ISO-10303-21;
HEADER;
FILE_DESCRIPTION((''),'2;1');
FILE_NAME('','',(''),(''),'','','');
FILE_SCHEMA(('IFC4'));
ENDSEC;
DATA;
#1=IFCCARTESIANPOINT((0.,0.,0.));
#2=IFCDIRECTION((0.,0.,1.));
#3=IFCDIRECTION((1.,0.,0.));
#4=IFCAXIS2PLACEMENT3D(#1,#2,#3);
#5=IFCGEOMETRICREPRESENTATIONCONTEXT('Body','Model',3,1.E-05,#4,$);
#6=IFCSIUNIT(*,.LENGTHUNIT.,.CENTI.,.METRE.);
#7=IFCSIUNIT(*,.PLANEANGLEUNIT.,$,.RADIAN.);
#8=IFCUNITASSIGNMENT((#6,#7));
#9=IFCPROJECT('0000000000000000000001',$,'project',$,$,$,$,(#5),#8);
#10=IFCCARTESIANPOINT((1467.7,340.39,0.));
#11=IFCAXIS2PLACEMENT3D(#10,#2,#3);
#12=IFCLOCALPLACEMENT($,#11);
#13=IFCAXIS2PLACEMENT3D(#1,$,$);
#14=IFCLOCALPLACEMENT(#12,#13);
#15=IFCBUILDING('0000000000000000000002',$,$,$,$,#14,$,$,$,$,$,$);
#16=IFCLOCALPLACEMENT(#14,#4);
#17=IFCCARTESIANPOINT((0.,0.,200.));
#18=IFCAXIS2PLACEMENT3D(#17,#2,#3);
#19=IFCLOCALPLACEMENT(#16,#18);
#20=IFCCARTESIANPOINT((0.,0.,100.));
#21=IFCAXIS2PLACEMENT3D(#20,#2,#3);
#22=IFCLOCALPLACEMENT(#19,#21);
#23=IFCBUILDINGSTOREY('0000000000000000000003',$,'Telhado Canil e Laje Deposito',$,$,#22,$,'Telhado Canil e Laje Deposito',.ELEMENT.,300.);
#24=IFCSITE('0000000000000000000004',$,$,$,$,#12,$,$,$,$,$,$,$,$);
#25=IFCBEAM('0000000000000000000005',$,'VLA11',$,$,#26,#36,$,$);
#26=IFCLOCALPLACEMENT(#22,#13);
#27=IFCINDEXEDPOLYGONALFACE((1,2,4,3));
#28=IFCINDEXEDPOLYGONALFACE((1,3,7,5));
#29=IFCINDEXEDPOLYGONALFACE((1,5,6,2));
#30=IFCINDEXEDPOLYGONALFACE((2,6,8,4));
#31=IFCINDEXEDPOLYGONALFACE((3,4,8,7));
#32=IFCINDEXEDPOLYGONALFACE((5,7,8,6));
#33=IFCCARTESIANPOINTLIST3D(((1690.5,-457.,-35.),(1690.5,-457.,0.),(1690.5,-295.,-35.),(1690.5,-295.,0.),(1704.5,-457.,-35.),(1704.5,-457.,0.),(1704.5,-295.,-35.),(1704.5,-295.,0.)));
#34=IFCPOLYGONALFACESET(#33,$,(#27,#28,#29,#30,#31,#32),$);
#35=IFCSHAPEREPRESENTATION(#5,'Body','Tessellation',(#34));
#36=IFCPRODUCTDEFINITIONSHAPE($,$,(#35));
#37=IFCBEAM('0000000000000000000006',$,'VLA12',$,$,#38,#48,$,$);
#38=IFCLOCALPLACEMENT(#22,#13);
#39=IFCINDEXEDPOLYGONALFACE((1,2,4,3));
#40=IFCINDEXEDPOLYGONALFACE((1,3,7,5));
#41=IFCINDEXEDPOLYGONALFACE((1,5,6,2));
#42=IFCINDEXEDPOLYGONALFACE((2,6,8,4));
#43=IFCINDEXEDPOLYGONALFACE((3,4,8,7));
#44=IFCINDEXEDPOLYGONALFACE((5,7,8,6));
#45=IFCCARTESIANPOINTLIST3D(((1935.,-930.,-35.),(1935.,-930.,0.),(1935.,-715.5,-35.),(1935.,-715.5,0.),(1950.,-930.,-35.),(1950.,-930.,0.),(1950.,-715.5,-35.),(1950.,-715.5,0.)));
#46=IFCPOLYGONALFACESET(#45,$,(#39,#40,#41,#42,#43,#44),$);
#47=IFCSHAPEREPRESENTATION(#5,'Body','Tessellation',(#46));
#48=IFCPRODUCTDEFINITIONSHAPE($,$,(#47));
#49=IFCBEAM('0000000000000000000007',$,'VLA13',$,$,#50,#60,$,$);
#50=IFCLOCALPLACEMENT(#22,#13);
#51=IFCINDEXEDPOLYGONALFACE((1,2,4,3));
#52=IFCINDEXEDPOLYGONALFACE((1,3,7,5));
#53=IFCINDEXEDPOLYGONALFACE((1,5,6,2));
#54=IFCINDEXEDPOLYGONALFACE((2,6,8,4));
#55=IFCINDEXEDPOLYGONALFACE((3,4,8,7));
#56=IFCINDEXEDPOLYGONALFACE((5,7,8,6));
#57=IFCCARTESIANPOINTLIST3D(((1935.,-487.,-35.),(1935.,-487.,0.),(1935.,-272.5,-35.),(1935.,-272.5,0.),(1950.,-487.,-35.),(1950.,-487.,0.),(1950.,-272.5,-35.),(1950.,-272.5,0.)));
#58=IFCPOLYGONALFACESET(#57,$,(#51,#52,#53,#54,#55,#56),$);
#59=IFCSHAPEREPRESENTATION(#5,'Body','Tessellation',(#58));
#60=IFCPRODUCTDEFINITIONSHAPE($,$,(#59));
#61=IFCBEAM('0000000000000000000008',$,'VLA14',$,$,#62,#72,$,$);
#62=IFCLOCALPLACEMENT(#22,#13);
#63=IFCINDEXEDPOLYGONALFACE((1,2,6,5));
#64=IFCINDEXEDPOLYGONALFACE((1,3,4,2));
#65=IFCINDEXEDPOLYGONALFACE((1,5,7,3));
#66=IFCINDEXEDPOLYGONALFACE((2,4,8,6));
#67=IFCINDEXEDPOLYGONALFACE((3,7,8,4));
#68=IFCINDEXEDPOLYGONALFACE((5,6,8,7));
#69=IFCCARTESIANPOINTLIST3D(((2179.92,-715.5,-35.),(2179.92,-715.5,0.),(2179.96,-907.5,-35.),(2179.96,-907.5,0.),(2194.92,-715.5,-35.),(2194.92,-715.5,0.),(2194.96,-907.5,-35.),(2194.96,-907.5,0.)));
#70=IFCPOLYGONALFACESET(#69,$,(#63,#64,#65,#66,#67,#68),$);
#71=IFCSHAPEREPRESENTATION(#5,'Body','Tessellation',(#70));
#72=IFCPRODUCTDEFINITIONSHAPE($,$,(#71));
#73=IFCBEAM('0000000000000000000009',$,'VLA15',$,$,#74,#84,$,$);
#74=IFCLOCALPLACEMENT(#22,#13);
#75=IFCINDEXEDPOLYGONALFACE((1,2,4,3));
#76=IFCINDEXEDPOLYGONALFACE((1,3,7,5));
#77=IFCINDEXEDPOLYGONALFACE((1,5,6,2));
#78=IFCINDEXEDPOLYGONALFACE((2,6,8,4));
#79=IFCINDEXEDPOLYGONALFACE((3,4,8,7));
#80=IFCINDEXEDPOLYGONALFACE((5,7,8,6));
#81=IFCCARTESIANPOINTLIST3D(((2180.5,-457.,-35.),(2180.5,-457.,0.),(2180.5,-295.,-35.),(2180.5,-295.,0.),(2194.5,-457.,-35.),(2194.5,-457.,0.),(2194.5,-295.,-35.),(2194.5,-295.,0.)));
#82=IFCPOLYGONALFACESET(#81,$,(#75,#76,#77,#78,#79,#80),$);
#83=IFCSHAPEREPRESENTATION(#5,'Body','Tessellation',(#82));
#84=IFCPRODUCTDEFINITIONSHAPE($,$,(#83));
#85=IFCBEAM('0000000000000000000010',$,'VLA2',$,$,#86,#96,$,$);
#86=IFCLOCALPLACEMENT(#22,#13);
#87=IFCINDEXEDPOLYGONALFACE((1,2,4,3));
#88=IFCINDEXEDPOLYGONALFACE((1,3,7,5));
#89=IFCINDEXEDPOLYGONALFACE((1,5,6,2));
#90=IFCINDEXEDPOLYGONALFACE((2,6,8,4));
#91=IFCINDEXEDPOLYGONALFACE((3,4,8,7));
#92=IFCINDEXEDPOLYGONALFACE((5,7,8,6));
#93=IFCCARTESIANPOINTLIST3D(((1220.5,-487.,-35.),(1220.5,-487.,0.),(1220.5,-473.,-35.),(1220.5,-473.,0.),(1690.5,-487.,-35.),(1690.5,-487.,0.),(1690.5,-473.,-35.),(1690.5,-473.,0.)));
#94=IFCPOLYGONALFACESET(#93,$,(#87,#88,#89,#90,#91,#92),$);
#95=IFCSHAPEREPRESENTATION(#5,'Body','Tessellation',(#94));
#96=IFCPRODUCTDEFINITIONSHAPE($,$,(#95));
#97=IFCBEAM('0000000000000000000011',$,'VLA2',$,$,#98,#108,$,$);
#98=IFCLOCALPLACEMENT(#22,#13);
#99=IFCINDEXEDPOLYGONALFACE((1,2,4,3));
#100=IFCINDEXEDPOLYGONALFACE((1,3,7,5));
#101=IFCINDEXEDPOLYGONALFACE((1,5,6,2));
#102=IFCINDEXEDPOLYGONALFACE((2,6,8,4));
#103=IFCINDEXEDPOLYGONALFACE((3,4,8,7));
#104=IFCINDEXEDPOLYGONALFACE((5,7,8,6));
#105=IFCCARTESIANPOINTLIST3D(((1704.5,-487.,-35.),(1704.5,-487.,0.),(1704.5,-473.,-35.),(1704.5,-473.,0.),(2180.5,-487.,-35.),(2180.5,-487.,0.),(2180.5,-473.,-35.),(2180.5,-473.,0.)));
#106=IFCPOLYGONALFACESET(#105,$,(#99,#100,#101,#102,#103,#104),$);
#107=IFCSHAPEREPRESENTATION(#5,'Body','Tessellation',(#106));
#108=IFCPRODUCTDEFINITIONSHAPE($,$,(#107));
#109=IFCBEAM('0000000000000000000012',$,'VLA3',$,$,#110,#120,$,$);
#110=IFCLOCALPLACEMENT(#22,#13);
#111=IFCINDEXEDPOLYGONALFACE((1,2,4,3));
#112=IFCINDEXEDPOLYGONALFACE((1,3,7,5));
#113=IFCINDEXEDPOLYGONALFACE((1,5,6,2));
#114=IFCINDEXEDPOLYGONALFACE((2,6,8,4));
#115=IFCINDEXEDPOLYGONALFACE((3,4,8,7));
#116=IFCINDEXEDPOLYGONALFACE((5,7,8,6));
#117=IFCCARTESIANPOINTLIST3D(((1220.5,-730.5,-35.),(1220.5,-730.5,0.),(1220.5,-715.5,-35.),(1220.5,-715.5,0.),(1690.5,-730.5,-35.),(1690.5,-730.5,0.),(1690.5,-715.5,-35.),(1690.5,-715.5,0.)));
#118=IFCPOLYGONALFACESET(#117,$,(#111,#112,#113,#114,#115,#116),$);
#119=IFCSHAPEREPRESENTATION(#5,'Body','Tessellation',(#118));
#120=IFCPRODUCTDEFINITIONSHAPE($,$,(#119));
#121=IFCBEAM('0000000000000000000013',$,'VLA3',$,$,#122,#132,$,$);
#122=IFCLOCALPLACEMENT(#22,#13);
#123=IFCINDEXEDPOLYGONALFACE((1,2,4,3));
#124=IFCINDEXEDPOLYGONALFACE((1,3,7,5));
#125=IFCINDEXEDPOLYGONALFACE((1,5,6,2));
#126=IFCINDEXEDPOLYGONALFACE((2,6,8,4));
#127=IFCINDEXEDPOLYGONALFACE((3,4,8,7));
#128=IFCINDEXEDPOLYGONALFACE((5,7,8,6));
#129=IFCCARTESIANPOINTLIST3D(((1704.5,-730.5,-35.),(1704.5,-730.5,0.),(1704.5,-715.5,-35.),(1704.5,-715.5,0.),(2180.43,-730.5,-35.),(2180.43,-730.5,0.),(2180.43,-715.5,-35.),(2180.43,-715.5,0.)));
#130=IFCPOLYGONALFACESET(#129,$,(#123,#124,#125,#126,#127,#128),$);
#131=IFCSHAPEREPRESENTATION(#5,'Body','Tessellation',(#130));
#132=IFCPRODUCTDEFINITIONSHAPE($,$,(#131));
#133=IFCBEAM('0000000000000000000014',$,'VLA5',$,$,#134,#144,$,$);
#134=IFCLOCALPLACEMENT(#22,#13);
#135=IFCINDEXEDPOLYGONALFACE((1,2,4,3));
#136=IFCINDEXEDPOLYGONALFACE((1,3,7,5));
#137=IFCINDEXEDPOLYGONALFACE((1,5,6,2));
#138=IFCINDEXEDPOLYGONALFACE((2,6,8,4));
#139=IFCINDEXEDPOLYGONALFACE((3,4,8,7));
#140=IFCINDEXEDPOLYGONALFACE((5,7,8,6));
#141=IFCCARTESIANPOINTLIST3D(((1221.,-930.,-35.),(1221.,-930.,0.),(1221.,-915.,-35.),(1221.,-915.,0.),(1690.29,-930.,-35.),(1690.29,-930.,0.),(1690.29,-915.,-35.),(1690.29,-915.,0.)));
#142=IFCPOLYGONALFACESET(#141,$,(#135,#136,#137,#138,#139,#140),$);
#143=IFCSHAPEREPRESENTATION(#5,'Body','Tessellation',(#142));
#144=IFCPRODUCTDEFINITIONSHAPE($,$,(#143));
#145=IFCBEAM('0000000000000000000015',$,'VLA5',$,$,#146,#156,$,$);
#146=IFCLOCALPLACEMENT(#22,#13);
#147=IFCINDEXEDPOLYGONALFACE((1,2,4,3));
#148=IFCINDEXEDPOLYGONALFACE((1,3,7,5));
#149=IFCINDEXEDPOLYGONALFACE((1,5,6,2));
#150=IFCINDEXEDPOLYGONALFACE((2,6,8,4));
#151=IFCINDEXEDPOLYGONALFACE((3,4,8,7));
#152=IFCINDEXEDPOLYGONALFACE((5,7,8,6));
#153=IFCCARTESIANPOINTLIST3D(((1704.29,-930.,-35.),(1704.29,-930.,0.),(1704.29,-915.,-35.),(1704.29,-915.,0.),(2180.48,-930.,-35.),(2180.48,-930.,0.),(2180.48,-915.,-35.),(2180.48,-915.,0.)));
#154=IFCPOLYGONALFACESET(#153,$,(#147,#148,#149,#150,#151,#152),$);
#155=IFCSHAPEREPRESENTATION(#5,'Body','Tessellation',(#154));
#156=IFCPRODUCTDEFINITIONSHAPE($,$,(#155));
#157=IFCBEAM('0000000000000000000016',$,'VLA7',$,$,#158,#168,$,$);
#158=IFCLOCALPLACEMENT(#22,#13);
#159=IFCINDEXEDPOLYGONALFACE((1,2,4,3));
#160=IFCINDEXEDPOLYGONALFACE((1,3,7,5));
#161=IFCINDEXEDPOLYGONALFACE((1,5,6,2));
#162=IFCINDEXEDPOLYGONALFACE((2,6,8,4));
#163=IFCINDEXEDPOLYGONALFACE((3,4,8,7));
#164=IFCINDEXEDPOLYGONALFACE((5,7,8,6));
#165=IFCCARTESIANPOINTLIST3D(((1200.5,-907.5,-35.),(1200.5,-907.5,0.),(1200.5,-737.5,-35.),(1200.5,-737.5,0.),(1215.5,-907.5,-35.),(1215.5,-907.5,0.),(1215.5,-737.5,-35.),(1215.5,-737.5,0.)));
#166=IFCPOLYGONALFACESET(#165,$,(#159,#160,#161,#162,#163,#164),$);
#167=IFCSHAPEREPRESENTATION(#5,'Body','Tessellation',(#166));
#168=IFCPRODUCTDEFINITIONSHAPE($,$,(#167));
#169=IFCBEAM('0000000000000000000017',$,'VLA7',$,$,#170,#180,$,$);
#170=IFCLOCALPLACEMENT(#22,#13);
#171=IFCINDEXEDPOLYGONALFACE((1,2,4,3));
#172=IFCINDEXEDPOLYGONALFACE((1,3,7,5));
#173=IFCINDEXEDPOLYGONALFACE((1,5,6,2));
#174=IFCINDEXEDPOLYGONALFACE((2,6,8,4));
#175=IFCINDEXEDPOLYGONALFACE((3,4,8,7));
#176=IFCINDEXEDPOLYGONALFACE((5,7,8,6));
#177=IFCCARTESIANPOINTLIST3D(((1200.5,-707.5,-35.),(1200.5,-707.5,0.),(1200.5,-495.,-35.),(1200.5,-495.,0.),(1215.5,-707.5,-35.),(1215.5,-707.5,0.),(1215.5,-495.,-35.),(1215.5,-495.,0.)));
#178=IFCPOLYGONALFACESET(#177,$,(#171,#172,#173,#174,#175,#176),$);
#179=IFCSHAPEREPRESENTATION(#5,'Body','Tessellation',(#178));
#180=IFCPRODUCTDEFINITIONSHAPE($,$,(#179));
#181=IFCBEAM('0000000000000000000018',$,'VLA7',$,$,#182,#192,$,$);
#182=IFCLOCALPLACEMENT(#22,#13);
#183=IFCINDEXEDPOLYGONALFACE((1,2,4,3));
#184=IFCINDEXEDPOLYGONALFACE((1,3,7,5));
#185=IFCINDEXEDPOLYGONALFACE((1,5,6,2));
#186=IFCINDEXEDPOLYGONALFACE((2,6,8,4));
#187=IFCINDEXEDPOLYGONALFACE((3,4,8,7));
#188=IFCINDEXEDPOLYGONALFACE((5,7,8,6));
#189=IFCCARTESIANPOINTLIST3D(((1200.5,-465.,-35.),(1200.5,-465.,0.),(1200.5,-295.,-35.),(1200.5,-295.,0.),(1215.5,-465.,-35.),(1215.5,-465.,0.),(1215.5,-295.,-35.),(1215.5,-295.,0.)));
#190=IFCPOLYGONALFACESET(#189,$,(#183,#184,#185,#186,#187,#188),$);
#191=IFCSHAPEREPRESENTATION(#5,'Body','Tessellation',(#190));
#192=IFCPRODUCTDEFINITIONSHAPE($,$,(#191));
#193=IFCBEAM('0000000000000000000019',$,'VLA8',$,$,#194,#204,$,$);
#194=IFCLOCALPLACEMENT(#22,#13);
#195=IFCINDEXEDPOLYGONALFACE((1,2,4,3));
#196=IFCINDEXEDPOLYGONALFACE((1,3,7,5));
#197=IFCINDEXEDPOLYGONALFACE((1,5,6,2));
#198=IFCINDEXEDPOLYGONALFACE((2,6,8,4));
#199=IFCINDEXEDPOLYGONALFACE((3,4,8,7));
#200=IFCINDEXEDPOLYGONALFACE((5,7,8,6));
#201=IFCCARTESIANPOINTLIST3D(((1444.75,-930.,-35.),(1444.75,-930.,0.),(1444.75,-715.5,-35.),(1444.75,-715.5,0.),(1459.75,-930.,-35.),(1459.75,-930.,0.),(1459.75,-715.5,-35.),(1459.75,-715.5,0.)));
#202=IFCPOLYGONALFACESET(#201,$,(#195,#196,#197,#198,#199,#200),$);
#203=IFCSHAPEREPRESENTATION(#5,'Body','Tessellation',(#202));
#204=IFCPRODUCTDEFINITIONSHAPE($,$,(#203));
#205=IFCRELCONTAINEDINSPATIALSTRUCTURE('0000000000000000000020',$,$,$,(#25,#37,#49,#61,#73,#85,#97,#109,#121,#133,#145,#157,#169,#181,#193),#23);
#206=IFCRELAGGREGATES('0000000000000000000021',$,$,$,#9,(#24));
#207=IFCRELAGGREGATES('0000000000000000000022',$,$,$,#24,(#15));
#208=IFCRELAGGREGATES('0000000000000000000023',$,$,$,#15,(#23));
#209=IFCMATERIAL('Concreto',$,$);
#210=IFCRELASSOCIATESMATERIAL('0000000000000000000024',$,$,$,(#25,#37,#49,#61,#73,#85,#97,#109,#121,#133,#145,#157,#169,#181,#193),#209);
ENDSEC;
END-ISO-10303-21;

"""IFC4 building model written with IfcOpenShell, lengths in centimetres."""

from ifc_helpers import new_model, si_unit, frame, origin, origin_with_axes, origin_2d_with_axis, place, context, project, spatial, rectangle, extrude, material, element, save


model = new_model("IFC4")

# Units and contexts
model_context = context("Model", 3, precision=1e-05, world=origin_with_axes(), identifier="Body")
ifc_project = project(units=[si_unit("LENGTHUNIT", "METRE", prefix="CENTI"), si_unit("PLANEANGLEUNIT", "RADIAN")], contexts=[model_context])

# Site, building, storey
site_placement = place(None, frame((1467.7, 340.39, 0.0), z_axis=(0.0, 0.0, 1.0), x_axis=(1.0, 0.0, 0.0)))
site = spatial("IfcSite", under=ifc_project, at=site_placement)
building_placement = place(site_placement, origin())
building = spatial("IfcBuilding", under=site, at=building_placement)
placement_1 = place(building_placement, origin_with_axes())
placement_2 = place(placement_1, frame((0.0, 0.0, 200.0), z_axis=(0.0, 0.0, 1.0), x_axis=(1.0, 0.0, 0.0)))
storey_placement = place(placement_2, frame((0.0, 0.0, 100.0), z_axis=(0.0, 0.0, 1.0), x_axis=(1.0, 0.0, 0.0)))
storey = spatial("IfcBuildingStorey", under=building, at=storey_placement, Name="Telhado Canil e Laje Deposito", LongName="Telhado Canil e Laje Deposito", CompositionType="ELEMENT", Elevation=300.0)

# Shared definitions
ifc_material = material(Name="Concreto")

# Beams
beam_1_placement = place(storey_placement, frame((1697.5, -376.0, 0.0), z_axis=(0.0, 0.0, 1.0), x_axis=(1.0, 0.0, 0.0)))
element("IfcBeam", 1, at=beam_1_placement, inside=storey, material=ifc_material, Name="VLA11", context=model_context, shape_type="SolidModel", body=[
    extrude(rectangle(XDim=14.0, YDim=35.0, at=origin_2d_with_axis()), frame((0.0, -81.0, -17.5), z_axis=(0.0, 1.0, 0.0), x_axis=(1.0, 0.0, 0.0)), (0.0, 0.0, 1.0), 162.0),
])
for number, where, z_axis, x_axis, name in (
    (2, (1942.5, -822.75, 0.0), (0.0, 0.0, 1.0), (1.0, 0.0, 0.0), "VLA12"),
    (3, (1942.5, -379.75, 0.0), (0.0, 0.0, 1.0), (1.0, 0.0, 0.0), "VLA13"),
):
    element("IfcBeam", number, at=place(storey_placement, frame(where, z_axis=z_axis, x_axis=x_axis)), inside=storey, material=ifc_material, Name=name, context=model_context, shape_type="SolidModel", body=[
        extrude(rectangle(XDim=15.0, YDim=35.0, at=origin_2d_with_axis()), frame((0.0, -107.25, -17.5), z_axis=(0.0, 1.0, 0.0), x_axis=(1.0, 0.0, 0.0)), (0.0, 0.0, 1.0), 214.5),
    ])
beam_2_placement = place(storey_placement, frame((2187.44, -811.5, 0.0), z_axis=(0.0, 0.0, 1.0), x_axis=(1.0, 0.0, 0.0)))
element("IfcBeam", 4, at=beam_2_placement, inside=storey, material=ifc_material, Name="VLA14", context=model_context, shape_type="SolidModel", body=[
    extrude(rectangle(XDim=15.0, YDim=35.0, at=origin_2d_with_axis()), frame((0.02, -96.0, -17.5), z_axis=(-0.000185, 1.0, 0.0), x_axis=(1.0, 0.000185, 0.0)), (0.0, 0.0, 1.0), 192.0),
])
beam_3_placement = place(storey_placement, frame((2187.5, -376.0, 0.0), z_axis=(0.0, 0.0, 1.0), x_axis=(1.0, 0.0, 0.0)))
element("IfcBeam", 5, at=beam_3_placement, inside=storey, material=ifc_material, Name="VLA15", context=model_context, shape_type="SolidModel", body=[
    extrude(rectangle(XDim=14.0, YDim=35.0, at=origin_2d_with_axis()), frame((0.0, -81.0, -17.5), z_axis=(0.0, 1.0, 0.0), x_axis=(1.0, 0.0, 0.0)), (0.0, 0.0, 1.0), 162.0),
])
beam_4_placement = place(storey_placement, frame((1455.5, -480.0, 0.0), z_axis=(0.0, 0.0, 1.0), x_axis=(1.0, 0.0, 0.0)))
element("IfcBeam", 6, at=beam_4_placement, inside=storey, material=ifc_material, Name="VLA2", context=model_context, shape_type="SolidModel", body=[
    extrude(rectangle(XDim=14.0, YDim=35.0, at=origin_2d_with_axis()), frame((-235.0, 0.0, -17.5), z_axis=(1.0, 0.0, 0.0), x_axis=(0.0, 1.0, 0.0)), (0.0, 0.0, 1.0), 470.0),
])
beam_5_placement = place(storey_placement, frame((1942.5, -480.0, 0.0), z_axis=(0.0, 0.0, 1.0), x_axis=(1.0, 0.0, 0.0)))
element("IfcBeam", 7, at=beam_5_placement, inside=storey, material=ifc_material, Name="VLA2", context=model_context, shape_type="SolidModel", body=[
    extrude(rectangle(XDim=14.0, YDim=35.0, at=origin_2d_with_axis()), frame((-238.0, 0.0, -17.5), z_axis=(1.0, 0.0, 0.0), x_axis=(0.0, 1.0, 0.0)), (0.0, 0.0, 1.0), 476.0),
])
beam_6_placement = place(storey_placement, frame((1455.5, -723.0, 0.0), z_axis=(0.0, 0.0, 1.0), x_axis=(1.0, 0.0, 0.0)))
element("IfcBeam", 8, at=beam_6_placement, inside=storey, material=ifc_material, Name="VLA3", context=model_context, shape_type="SolidModel", body=[
    extrude(rectangle(XDim=15.0, YDim=35.0, at=origin_2d_with_axis()), frame((-235.0, 0.0, -17.5), z_axis=(1.0, 0.0, 0.0), x_axis=(0.0, 1.0, 0.0)), (0.0, 0.0, 1.0), 470.0),
])
beam_7_placement = place(storey_placement, frame((1942.46, -723.0, 0.0), z_axis=(0.0, 0.0, 1.0), x_axis=(1.0, 0.0, 0.0)))
element("IfcBeam", 9, at=beam_7_placement, inside=storey, material=ifc_material, Name="VLA3", context=model_context, shape_type="SolidModel", body=[
    extrude(rectangle(XDim=15.0, YDim=35.0, at=origin_2d_with_axis()), frame((-237.97, 0.0, -17.5), z_axis=(1.0, 0.0, 0.0), x_axis=(0.0, 1.0, 0.0)), (0.0, 0.0, 1.0), 475.93),
])
beam_8_placement = place(storey_placement, frame((1455.64, -922.5, 0.0), z_axis=(0.0, 0.0, 1.0), x_axis=(1.0, 0.0, 0.0)))
element("IfcBeam", 10, at=beam_8_placement, inside=storey, material=ifc_material, Name="VLA5", context=model_context, shape_type="SolidModel", body=[
    extrude(rectangle(XDim=15.0, YDim=35.0, at=origin_2d_with_axis()), frame((-234.65, 0.0, -17.5), z_axis=(1.0, 0.0, 0.0), x_axis=(0.0, -1.0, 0.0)), (0.0, 0.0, 1.0), 469.29),
])
beam_9_placement = place(storey_placement, frame((1942.38, -922.5, 0.0), z_axis=(0.0, 0.0, 1.0), x_axis=(1.0, 0.0, 0.0)))
element("IfcBeam", 11, at=beam_9_placement, inside=storey, material=ifc_material, Name="VLA5", context=model_context, shape_type="SolidModel", body=[
    extrude(rectangle(XDim=15.0, YDim=35.0, at=origin_2d_with_axis()), frame((-238.09, 0.0, -17.5), z_axis=(1.0, 0.0, 0.0), x_axis=(0.0, 1.0, 0.0)), (0.0, 0.0, 1.0), 476.19),
])
beam_10_placement = place(storey_placement, frame((1208.0, -822.5, 0.0), z_axis=(0.0, 0.0, 1.0), x_axis=(1.0, 0.0, 0.0)))
element("IfcBeam", 12, at=beam_10_placement, inside=storey, material=ifc_material, Name="VLA7", context=model_context, shape_type="SolidModel", body=[
    extrude(rectangle(XDim=15.0, YDim=35.0, at=origin_2d_with_axis()), frame((0.0, -85.0, -17.5), z_axis=(0.0, 1.0, 0.0), x_axis=(1.0, 0.0, 0.0)), (0.0, 0.0, 1.0), 170.0),
])
beam_11_placement = place(storey_placement, frame((1208.0, -601.25, 0.0), z_axis=(0.0, 0.0, 1.0), x_axis=(1.0, 0.0, 0.0)))
element("IfcBeam", 13, at=beam_11_placement, inside=storey, material=ifc_material, Name="VLA7", context=model_context, shape_type="SolidModel", body=[
    extrude(rectangle(XDim=15.0, YDim=35.0, at=origin_2d_with_axis()), frame((0.0, -106.25, -17.5), z_axis=(0.0, 1.0, 0.0), x_axis=(1.0, 0.0, 0.0)), (0.0, 0.0, 1.0), 212.5),
])
beam_12_placement = place(storey_placement, frame((1208.0, -380.0, 0.0), z_axis=(0.0, 0.0, 1.0), x_axis=(1.0, 0.0, 0.0)))
element("IfcBeam", 14, at=beam_12_placement, inside=storey, material=ifc_material, Name="VLA7", context=model_context, shape_type="SolidModel", body=[
    extrude(rectangle(XDim=15.0, YDim=35.0, at=origin_2d_with_axis()), frame((0.0, -85.0, -17.5), z_axis=(0.0, 1.0, 0.0), x_axis=(1.0, 0.0, 0.0)), (0.0, 0.0, 1.0), 170.0),
])
for number, where, z_axis, x_axis, name in (
    (15, (1452.25, -822.75, 0.0), (0.0, 0.0, 1.0), (1.0, 0.0, 0.0), "VLA8"),
):
    element("IfcBeam", number, at=place(storey_placement, frame(where, z_axis=z_axis, x_axis=x_axis)), inside=storey, material=ifc_material, Name=name, context=model_context, shape_type="SolidModel", body=[
        extrude(rectangle(XDim=15.0, YDim=35.0, at=origin_2d_with_axis()), frame((0.0, -107.25, -17.5), z_axis=(0.0, 1.0, 0.0), x_axis=(1.0, 0.0, 0.0)), (0.0, 0.0, 1.0), 214.5),
    ])

save(model, "model.ifc")
